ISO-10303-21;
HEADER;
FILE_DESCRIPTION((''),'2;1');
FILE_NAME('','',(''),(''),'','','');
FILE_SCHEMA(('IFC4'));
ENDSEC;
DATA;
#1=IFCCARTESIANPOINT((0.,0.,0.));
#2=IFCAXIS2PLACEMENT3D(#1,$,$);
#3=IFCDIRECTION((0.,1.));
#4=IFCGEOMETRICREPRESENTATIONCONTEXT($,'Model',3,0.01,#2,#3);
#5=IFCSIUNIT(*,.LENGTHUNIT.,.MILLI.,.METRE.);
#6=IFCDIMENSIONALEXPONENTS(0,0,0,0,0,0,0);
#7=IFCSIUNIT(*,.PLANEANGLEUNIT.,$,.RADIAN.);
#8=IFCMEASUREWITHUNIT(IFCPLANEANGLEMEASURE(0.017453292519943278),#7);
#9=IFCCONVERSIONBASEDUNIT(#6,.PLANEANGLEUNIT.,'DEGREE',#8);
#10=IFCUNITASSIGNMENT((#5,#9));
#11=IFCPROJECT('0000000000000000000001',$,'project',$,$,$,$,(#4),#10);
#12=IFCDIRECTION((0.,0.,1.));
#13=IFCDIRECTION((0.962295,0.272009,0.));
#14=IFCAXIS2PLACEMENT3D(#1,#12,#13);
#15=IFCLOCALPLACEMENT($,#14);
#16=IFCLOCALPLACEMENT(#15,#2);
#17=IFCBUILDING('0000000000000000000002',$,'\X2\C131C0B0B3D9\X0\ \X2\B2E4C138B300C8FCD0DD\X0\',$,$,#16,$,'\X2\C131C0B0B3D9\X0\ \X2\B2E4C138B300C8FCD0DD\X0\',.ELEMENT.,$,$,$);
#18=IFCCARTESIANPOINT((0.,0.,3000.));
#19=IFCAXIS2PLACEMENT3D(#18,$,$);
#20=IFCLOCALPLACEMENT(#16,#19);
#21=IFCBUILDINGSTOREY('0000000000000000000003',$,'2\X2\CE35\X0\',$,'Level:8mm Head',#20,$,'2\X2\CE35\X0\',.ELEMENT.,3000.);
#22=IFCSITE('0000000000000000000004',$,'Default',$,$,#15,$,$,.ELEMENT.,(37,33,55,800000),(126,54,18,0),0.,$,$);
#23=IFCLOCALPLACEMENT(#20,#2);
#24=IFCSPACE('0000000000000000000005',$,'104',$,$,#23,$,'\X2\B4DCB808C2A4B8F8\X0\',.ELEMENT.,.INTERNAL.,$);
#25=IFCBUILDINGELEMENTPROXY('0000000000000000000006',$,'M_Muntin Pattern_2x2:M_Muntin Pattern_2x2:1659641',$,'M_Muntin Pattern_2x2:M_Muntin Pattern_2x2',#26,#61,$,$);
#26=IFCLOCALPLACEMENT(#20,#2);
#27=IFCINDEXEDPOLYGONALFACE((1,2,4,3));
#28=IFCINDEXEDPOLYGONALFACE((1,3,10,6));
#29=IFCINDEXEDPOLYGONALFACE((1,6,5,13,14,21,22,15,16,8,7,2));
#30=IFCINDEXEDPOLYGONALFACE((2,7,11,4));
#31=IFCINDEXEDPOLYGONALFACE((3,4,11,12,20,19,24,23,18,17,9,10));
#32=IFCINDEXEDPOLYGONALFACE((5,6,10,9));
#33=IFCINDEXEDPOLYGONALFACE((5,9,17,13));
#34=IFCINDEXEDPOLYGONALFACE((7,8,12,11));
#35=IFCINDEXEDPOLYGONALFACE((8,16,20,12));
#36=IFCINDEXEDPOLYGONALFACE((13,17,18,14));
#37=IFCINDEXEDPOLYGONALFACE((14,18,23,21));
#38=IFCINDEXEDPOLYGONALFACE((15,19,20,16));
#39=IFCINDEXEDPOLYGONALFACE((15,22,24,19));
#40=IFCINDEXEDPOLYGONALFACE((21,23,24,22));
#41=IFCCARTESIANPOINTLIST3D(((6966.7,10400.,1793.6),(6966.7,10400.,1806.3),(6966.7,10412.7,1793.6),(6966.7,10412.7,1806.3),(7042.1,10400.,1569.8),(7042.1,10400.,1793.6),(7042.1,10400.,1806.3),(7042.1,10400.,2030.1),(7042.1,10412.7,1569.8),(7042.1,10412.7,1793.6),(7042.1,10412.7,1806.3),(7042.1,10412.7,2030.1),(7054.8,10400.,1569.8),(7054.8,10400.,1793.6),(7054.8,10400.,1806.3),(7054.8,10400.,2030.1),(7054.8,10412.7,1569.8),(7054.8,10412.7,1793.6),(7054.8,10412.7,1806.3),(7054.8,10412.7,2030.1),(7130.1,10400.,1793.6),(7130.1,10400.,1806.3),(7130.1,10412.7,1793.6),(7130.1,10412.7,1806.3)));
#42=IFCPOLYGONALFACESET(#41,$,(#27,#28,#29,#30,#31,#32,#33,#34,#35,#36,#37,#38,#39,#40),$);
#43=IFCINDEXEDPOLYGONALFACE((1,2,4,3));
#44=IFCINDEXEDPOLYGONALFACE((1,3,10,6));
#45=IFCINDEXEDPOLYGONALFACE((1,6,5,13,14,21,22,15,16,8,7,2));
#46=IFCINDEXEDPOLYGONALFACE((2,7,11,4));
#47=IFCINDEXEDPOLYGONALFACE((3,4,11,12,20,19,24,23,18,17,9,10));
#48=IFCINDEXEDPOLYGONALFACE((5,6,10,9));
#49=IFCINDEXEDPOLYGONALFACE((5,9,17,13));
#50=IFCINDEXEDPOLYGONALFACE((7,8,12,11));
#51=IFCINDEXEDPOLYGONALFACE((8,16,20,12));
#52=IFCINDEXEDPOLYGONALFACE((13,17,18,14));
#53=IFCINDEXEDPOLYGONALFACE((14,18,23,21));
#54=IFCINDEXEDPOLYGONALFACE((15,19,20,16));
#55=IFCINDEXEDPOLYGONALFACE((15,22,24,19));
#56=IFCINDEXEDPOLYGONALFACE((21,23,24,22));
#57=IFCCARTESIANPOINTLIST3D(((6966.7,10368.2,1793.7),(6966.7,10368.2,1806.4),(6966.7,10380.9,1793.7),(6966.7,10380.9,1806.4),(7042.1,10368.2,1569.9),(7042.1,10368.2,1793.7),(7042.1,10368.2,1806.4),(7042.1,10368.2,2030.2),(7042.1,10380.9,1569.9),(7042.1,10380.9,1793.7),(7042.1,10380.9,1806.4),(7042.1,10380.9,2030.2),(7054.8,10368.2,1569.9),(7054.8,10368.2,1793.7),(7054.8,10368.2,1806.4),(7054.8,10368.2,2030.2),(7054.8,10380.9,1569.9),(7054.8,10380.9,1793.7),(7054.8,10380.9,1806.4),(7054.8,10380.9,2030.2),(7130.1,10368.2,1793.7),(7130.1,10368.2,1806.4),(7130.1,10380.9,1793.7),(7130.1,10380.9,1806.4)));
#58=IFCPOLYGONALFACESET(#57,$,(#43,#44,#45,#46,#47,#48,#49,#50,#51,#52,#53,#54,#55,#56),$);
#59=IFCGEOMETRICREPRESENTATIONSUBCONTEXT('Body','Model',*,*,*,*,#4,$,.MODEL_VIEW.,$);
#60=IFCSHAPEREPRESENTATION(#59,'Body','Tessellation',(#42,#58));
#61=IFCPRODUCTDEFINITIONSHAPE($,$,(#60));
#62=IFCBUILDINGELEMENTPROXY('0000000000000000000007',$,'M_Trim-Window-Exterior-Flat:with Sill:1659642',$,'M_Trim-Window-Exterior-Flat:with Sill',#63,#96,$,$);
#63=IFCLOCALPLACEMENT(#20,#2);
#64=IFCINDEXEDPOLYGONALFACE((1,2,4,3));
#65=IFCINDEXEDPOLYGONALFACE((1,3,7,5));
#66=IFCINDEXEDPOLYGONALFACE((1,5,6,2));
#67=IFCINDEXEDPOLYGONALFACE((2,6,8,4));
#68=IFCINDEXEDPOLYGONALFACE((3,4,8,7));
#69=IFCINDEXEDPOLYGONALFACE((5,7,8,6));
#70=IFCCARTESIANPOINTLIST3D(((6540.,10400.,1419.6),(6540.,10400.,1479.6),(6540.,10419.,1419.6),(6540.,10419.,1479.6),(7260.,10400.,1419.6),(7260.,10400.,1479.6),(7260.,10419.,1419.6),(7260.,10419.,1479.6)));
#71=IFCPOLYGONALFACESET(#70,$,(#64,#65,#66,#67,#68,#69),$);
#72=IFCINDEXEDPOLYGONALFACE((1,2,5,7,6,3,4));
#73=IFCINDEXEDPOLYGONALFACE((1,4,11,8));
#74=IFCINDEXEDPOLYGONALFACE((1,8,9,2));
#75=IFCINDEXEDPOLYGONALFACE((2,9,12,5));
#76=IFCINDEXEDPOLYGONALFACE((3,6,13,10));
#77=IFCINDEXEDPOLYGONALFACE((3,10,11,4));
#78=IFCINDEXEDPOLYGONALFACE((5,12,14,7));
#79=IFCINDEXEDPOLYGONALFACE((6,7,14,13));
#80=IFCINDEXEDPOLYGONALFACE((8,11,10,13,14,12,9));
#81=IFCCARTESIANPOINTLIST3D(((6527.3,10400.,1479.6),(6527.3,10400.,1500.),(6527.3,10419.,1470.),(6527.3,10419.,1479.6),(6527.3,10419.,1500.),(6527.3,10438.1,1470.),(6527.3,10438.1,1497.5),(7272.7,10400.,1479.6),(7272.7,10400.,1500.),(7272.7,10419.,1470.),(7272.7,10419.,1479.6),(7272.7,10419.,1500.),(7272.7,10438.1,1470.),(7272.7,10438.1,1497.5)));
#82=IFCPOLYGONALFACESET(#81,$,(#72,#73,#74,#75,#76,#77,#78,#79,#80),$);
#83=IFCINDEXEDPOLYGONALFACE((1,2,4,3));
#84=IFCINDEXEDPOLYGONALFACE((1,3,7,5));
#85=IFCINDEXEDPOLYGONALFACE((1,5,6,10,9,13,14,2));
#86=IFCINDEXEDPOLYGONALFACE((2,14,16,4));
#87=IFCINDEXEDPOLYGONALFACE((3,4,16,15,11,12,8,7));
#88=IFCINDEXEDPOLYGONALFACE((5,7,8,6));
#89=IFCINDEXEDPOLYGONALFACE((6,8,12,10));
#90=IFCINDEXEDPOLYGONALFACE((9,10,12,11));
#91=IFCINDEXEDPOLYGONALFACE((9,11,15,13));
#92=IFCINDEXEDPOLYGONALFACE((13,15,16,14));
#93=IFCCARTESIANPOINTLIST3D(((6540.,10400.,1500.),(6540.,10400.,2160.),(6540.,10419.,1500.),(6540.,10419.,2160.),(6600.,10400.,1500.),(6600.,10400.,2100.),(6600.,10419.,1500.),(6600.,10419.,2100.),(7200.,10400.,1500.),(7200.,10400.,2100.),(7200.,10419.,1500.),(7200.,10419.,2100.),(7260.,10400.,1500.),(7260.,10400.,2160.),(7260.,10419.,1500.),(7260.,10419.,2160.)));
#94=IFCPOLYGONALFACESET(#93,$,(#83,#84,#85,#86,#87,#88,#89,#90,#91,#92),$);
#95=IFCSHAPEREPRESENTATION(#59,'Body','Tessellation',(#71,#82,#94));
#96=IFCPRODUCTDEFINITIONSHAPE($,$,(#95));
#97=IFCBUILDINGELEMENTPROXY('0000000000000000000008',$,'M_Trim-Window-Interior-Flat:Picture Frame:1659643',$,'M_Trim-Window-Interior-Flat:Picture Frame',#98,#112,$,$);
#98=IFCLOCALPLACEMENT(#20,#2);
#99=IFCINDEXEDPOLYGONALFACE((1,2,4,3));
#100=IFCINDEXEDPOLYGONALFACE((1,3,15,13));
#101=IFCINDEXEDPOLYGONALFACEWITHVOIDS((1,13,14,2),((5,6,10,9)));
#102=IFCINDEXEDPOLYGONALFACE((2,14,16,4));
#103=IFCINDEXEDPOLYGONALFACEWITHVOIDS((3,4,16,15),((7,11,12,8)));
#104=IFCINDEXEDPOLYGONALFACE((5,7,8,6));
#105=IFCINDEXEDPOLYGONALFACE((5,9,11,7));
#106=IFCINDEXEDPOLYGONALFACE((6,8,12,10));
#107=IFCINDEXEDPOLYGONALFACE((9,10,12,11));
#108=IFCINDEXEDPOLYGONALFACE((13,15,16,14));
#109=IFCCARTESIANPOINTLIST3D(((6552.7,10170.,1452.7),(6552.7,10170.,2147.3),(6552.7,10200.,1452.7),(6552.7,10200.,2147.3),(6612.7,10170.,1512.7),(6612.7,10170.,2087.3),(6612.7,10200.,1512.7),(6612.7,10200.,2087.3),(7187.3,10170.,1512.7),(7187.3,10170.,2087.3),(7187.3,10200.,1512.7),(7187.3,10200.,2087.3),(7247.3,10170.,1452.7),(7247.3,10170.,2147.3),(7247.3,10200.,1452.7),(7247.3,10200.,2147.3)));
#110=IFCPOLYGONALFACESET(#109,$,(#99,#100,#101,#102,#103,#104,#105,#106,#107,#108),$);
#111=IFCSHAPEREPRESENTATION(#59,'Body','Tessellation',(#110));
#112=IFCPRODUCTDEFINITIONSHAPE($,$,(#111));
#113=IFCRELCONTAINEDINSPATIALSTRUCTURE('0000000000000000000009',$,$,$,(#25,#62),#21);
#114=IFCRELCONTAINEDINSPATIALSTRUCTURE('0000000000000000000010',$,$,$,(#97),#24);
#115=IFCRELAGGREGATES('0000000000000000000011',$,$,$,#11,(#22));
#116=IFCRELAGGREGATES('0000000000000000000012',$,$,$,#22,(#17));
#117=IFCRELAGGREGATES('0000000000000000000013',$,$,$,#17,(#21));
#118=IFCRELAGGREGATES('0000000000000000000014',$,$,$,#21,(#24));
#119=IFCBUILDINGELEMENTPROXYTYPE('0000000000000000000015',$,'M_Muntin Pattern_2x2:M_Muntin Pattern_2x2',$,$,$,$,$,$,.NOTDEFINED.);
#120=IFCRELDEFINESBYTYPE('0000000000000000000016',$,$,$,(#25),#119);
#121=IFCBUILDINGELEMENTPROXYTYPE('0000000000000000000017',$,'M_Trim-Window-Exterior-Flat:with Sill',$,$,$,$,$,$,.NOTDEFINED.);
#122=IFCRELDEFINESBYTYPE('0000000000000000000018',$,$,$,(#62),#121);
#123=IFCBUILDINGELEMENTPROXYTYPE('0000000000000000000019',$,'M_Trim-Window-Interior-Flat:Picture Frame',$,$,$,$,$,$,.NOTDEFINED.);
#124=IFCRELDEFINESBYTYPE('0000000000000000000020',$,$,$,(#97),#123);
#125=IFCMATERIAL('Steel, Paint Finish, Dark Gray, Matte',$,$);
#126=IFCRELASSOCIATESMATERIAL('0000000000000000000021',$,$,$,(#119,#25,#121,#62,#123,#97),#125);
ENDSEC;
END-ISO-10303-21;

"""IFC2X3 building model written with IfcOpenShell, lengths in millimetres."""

from ifc_helpers import new_model, entity, si_unit, converted_unit, direction, frame, frame_2d, origin, place, context, subcontext, project, spatial, polyline, rectangle, outline, extrude, source, transform, mapped, material, type_object, type_shapes, element, save


model = new_model("IFC2X3")

# Units and contexts
model_context = context("Model", 3, precision=0.01, world=origin(), true_north=direction((0.0, 1.0)))
body_context = subcontext(model_context, "Body", "Model", "MODEL_VIEW")
ifc_project = project(units=[si_unit("LENGTHUNIT", "METRE", prefix="MILLI"), converted_unit("PLANEANGLEUNIT", "DEGREE", entity("IfcPlaneAngleMeasure", 0.017453292519943278), si_unit("PLANEANGLEUNIT", "RADIAN"), dimensions=[0, 0, 0, 0, 0, 0, 0])], contexts=[model_context])

# Site, building, storey
site_placement = place(None, frame((0.0, 0.0, 0.0), z_axis=(0.0, 0.0, 1.0), x_axis=(0.962295, 0.272009, 0.0)))
site = spatial("IfcSite", under=ifc_project, at=site_placement, Name="Default", CompositionType="ELEMENT", RefLatitude=(37, 33, 55, 800000), RefLongitude=(126, 54, 18, 0), RefElevation=0.0)
building_placement = place(site_placement, origin())
building = spatial("IfcBuilding", under=site, at=building_placement, Name="성산동 다세대주택", LongName="성산동 다세대주택", CompositionType="ELEMENT")
storey_placement = place(building_placement, frame((0.0, 0.0, 3000.0)))
storey = spatial("IfcBuildingStorey", under=building, at=storey_placement, Name="2층", ObjectType="Level:8mm Head", LongName="2층", CompositionType="ELEMENT", Elevation=3000.0)

# Shared definitions
space_1_placement = place(storey_placement, origin())
space_1 = spatial("IfcSpace", under=storey, at=space_1_placement, Name="104", LongName="드레스룸", CompositionType="ELEMENT", InteriorOrExteriorSpace="INTERNAL")

# Building element proxies
ifc_material_1 = material(Name="Steel, Paint Finish, Dark Gray, Matte")
building_element_proxy_type_1 = type_object("IfcBuildingElementProxyType", Name="M_Muntin Pattern_2x2:M_Muntin Pattern_2x2", PredefinedType="NOTDEFINED", material=ifc_material_1)
shared_shape_1 = source(origin(), body_context, "Body", "SweptSolid", [
    extrude(outline(polyline([(6.4, -6.4), (230.1, -6.4), (230.1, 6.3), (6.4, 6.3), (6.4, 81.7), (-6.3, 81.7), (-6.3, 6.3), (-230.2, 6.3), (-230.2, -6.4), (-6.3, -6.4), (-6.3, -81.7), (6.4, -81.7), (6.4, -6.4)])), frame((0.0, -22.2, 230.1), z_axis=(0.0, 1.0, 0.0), x_axis=(0.0, 0.0, 1.0)), (0.0, 0.0, 1.0), 12.7),
    extrude(outline(polyline([(6.4, -6.4), (230.2, -6.4), (230.2, 6.3), (6.4, 6.3), (6.4, 81.7), (-6.3, 81.7), (-6.3, 6.3), (-230.2, 6.3), (-230.2, -6.4), (-6.3, -6.4), (-6.3, -81.7), (6.4, -81.7), (6.4, -6.4)])), frame((0.0, 9.5, 230.2), z_axis=(0.0, 1.0, 0.0), x_axis=(0.0, 0.0, 1.0)), (0.0, 0.0, 1.0), 12.7),
])
type_shapes(building_element_proxy_type_1, [shared_shape_1])
proxy_1_placement = place(storey_placement, frame((7048.4, 10390.5, 1569.9), z_axis=(0.0, 0.0, 1.0), x_axis=(-1.0, 0.0, 0.0)))
element("IfcBuildingElementProxy", 1, at=proxy_1_placement, inside=storey, type_object=building_element_proxy_type_1, material=ifc_material_1, Name="M_Muntin Pattern_2x2:M_Muntin Pattern_2x2:1659641", ObjectType="M_Muntin Pattern_2x2:M_Muntin Pattern_2x2", context=body_context, shape_type="MappedRepresentation", body=[
    mapped(shared_shape_1, transform((0.0, 0.0, 0.0), scale=1.0)),
])
building_element_proxy_type_2 = type_object("IfcBuildingElementProxyType", Name="M_Trim-Window-Exterior-Flat:with Sill", PredefinedType="NOTDEFINED", material=ifc_material_1)
shared_shape_2 = source(origin(), body_context, "Body", "SweptSolid", [
    extrude(rectangle(XDim=720.0, YDim=60.0, at=frame_2d((0.0, 0.0), x_axis=(1.0, 0.0))), frame((0.0, -650.4, 0.0), z_axis=(0.0, 0.0, 1.0), x_axis=(-1.0, 0.0, 0.0)), (0.0, 0.0, 1.0), 19.0),
    extrude(outline(polyline([(-19.0, -15.2), (0.0, -15.2), (0.0, -5.7), (19.0, -5.7), (19.0, 14.8), (0.0, 14.8), (-19.0, 12.3), (-19.0, -15.2)])), frame((-372.7, -614.8, 19.0), z_axis=(1.0, 0.0, 0.0), x_axis=(0.0, 0.0, -1.0)), (0.0, 0.0, 1.0), 745.4),
    extrude(outline(polyline([(-345.0, -360.0), (315.0, -360.0), (315.0, -300.0), (-285.0, -300.0), (-285.0, 300.0), (315.0, 300.0), (315.0, 360.0), (-345.0, 360.0), (-345.0, -360.0)])), frame((0.0, -285.0, 0.0), z_axis=(0.0, 0.0, 1.0), x_axis=(0.0, -1.0, 0.0)), (0.0, 0.0, 1.0), 19.0),
])
type_shapes(building_element_proxy_type_2, [shared_shape_2])
proxy_2_placement = place(storey_placement, frame((6900.0, 10400.0, 2100.0), z_axis=(0.0, 1.0, 0.0), x_axis=(-1.0, 0.0, 0.0)))
element("IfcBuildingElementProxy", 2, at=proxy_2_placement, inside=storey, type_object=building_element_proxy_type_2, material=ifc_material_1, Name="M_Trim-Window-Exterior-Flat:with Sill:1659642", ObjectType="M_Trim-Window-Exterior-Flat:with Sill", context=body_context, shape_type="MappedRepresentation", body=[
    mapped(shared_shape_2, transform((0.0, 0.0, 0.0), scale=1.0)),
])
building_element_proxy_type_3 = type_object("IfcBuildingElementProxyType", Name="M_Trim-Window-Interior-Flat:Picture Frame", PredefinedType="NOTDEFINED", material=ifc_material_1)
shared_shape_3 = source(origin(), body_context, "Body", "SweptSolid", [
    extrude(outline(polyline([(-347.3, -347.3), (347.3, -347.3), (347.3, 347.3), (-347.3, 347.3), (-347.3, -347.3)]), holes=[polyline([(-287.3, -287.3), (-287.3, 287.3), (287.3, 287.3), (287.3, -287.3), (-287.3, -287.3)])]), frame((0.0, -300.0, 0.0), z_axis=(0.0, 0.0, 1.0), x_axis=(-1.0, 0.0, 0.0)), (0.0, 0.0, 1.0), 30.0),
])
type_shapes(building_element_proxy_type_3, [shared_shape_3])
proxy_3_placement = place(space_1_placement, frame((6900.0, 10200.0, 2100.0), z_axis=(0.0, -1.0, 0.0), x_axis=(1.0, 0.0, 0.0)))
element("IfcBuildingElementProxy", 3, at=proxy_3_placement, inside=space_1, type_object=building_element_proxy_type_3, material=ifc_material_1, Name="M_Trim-Window-Interior-Flat:Picture Frame:1659643", ObjectType="M_Trim-Window-Interior-Flat:Picture Frame", context=body_context, shape_type="MappedRepresentation", body=[
    mapped(shared_shape_3, transform((0.0, 0.0, 0.0), scale=1.0)),
])

save(model, "model.ifc")
